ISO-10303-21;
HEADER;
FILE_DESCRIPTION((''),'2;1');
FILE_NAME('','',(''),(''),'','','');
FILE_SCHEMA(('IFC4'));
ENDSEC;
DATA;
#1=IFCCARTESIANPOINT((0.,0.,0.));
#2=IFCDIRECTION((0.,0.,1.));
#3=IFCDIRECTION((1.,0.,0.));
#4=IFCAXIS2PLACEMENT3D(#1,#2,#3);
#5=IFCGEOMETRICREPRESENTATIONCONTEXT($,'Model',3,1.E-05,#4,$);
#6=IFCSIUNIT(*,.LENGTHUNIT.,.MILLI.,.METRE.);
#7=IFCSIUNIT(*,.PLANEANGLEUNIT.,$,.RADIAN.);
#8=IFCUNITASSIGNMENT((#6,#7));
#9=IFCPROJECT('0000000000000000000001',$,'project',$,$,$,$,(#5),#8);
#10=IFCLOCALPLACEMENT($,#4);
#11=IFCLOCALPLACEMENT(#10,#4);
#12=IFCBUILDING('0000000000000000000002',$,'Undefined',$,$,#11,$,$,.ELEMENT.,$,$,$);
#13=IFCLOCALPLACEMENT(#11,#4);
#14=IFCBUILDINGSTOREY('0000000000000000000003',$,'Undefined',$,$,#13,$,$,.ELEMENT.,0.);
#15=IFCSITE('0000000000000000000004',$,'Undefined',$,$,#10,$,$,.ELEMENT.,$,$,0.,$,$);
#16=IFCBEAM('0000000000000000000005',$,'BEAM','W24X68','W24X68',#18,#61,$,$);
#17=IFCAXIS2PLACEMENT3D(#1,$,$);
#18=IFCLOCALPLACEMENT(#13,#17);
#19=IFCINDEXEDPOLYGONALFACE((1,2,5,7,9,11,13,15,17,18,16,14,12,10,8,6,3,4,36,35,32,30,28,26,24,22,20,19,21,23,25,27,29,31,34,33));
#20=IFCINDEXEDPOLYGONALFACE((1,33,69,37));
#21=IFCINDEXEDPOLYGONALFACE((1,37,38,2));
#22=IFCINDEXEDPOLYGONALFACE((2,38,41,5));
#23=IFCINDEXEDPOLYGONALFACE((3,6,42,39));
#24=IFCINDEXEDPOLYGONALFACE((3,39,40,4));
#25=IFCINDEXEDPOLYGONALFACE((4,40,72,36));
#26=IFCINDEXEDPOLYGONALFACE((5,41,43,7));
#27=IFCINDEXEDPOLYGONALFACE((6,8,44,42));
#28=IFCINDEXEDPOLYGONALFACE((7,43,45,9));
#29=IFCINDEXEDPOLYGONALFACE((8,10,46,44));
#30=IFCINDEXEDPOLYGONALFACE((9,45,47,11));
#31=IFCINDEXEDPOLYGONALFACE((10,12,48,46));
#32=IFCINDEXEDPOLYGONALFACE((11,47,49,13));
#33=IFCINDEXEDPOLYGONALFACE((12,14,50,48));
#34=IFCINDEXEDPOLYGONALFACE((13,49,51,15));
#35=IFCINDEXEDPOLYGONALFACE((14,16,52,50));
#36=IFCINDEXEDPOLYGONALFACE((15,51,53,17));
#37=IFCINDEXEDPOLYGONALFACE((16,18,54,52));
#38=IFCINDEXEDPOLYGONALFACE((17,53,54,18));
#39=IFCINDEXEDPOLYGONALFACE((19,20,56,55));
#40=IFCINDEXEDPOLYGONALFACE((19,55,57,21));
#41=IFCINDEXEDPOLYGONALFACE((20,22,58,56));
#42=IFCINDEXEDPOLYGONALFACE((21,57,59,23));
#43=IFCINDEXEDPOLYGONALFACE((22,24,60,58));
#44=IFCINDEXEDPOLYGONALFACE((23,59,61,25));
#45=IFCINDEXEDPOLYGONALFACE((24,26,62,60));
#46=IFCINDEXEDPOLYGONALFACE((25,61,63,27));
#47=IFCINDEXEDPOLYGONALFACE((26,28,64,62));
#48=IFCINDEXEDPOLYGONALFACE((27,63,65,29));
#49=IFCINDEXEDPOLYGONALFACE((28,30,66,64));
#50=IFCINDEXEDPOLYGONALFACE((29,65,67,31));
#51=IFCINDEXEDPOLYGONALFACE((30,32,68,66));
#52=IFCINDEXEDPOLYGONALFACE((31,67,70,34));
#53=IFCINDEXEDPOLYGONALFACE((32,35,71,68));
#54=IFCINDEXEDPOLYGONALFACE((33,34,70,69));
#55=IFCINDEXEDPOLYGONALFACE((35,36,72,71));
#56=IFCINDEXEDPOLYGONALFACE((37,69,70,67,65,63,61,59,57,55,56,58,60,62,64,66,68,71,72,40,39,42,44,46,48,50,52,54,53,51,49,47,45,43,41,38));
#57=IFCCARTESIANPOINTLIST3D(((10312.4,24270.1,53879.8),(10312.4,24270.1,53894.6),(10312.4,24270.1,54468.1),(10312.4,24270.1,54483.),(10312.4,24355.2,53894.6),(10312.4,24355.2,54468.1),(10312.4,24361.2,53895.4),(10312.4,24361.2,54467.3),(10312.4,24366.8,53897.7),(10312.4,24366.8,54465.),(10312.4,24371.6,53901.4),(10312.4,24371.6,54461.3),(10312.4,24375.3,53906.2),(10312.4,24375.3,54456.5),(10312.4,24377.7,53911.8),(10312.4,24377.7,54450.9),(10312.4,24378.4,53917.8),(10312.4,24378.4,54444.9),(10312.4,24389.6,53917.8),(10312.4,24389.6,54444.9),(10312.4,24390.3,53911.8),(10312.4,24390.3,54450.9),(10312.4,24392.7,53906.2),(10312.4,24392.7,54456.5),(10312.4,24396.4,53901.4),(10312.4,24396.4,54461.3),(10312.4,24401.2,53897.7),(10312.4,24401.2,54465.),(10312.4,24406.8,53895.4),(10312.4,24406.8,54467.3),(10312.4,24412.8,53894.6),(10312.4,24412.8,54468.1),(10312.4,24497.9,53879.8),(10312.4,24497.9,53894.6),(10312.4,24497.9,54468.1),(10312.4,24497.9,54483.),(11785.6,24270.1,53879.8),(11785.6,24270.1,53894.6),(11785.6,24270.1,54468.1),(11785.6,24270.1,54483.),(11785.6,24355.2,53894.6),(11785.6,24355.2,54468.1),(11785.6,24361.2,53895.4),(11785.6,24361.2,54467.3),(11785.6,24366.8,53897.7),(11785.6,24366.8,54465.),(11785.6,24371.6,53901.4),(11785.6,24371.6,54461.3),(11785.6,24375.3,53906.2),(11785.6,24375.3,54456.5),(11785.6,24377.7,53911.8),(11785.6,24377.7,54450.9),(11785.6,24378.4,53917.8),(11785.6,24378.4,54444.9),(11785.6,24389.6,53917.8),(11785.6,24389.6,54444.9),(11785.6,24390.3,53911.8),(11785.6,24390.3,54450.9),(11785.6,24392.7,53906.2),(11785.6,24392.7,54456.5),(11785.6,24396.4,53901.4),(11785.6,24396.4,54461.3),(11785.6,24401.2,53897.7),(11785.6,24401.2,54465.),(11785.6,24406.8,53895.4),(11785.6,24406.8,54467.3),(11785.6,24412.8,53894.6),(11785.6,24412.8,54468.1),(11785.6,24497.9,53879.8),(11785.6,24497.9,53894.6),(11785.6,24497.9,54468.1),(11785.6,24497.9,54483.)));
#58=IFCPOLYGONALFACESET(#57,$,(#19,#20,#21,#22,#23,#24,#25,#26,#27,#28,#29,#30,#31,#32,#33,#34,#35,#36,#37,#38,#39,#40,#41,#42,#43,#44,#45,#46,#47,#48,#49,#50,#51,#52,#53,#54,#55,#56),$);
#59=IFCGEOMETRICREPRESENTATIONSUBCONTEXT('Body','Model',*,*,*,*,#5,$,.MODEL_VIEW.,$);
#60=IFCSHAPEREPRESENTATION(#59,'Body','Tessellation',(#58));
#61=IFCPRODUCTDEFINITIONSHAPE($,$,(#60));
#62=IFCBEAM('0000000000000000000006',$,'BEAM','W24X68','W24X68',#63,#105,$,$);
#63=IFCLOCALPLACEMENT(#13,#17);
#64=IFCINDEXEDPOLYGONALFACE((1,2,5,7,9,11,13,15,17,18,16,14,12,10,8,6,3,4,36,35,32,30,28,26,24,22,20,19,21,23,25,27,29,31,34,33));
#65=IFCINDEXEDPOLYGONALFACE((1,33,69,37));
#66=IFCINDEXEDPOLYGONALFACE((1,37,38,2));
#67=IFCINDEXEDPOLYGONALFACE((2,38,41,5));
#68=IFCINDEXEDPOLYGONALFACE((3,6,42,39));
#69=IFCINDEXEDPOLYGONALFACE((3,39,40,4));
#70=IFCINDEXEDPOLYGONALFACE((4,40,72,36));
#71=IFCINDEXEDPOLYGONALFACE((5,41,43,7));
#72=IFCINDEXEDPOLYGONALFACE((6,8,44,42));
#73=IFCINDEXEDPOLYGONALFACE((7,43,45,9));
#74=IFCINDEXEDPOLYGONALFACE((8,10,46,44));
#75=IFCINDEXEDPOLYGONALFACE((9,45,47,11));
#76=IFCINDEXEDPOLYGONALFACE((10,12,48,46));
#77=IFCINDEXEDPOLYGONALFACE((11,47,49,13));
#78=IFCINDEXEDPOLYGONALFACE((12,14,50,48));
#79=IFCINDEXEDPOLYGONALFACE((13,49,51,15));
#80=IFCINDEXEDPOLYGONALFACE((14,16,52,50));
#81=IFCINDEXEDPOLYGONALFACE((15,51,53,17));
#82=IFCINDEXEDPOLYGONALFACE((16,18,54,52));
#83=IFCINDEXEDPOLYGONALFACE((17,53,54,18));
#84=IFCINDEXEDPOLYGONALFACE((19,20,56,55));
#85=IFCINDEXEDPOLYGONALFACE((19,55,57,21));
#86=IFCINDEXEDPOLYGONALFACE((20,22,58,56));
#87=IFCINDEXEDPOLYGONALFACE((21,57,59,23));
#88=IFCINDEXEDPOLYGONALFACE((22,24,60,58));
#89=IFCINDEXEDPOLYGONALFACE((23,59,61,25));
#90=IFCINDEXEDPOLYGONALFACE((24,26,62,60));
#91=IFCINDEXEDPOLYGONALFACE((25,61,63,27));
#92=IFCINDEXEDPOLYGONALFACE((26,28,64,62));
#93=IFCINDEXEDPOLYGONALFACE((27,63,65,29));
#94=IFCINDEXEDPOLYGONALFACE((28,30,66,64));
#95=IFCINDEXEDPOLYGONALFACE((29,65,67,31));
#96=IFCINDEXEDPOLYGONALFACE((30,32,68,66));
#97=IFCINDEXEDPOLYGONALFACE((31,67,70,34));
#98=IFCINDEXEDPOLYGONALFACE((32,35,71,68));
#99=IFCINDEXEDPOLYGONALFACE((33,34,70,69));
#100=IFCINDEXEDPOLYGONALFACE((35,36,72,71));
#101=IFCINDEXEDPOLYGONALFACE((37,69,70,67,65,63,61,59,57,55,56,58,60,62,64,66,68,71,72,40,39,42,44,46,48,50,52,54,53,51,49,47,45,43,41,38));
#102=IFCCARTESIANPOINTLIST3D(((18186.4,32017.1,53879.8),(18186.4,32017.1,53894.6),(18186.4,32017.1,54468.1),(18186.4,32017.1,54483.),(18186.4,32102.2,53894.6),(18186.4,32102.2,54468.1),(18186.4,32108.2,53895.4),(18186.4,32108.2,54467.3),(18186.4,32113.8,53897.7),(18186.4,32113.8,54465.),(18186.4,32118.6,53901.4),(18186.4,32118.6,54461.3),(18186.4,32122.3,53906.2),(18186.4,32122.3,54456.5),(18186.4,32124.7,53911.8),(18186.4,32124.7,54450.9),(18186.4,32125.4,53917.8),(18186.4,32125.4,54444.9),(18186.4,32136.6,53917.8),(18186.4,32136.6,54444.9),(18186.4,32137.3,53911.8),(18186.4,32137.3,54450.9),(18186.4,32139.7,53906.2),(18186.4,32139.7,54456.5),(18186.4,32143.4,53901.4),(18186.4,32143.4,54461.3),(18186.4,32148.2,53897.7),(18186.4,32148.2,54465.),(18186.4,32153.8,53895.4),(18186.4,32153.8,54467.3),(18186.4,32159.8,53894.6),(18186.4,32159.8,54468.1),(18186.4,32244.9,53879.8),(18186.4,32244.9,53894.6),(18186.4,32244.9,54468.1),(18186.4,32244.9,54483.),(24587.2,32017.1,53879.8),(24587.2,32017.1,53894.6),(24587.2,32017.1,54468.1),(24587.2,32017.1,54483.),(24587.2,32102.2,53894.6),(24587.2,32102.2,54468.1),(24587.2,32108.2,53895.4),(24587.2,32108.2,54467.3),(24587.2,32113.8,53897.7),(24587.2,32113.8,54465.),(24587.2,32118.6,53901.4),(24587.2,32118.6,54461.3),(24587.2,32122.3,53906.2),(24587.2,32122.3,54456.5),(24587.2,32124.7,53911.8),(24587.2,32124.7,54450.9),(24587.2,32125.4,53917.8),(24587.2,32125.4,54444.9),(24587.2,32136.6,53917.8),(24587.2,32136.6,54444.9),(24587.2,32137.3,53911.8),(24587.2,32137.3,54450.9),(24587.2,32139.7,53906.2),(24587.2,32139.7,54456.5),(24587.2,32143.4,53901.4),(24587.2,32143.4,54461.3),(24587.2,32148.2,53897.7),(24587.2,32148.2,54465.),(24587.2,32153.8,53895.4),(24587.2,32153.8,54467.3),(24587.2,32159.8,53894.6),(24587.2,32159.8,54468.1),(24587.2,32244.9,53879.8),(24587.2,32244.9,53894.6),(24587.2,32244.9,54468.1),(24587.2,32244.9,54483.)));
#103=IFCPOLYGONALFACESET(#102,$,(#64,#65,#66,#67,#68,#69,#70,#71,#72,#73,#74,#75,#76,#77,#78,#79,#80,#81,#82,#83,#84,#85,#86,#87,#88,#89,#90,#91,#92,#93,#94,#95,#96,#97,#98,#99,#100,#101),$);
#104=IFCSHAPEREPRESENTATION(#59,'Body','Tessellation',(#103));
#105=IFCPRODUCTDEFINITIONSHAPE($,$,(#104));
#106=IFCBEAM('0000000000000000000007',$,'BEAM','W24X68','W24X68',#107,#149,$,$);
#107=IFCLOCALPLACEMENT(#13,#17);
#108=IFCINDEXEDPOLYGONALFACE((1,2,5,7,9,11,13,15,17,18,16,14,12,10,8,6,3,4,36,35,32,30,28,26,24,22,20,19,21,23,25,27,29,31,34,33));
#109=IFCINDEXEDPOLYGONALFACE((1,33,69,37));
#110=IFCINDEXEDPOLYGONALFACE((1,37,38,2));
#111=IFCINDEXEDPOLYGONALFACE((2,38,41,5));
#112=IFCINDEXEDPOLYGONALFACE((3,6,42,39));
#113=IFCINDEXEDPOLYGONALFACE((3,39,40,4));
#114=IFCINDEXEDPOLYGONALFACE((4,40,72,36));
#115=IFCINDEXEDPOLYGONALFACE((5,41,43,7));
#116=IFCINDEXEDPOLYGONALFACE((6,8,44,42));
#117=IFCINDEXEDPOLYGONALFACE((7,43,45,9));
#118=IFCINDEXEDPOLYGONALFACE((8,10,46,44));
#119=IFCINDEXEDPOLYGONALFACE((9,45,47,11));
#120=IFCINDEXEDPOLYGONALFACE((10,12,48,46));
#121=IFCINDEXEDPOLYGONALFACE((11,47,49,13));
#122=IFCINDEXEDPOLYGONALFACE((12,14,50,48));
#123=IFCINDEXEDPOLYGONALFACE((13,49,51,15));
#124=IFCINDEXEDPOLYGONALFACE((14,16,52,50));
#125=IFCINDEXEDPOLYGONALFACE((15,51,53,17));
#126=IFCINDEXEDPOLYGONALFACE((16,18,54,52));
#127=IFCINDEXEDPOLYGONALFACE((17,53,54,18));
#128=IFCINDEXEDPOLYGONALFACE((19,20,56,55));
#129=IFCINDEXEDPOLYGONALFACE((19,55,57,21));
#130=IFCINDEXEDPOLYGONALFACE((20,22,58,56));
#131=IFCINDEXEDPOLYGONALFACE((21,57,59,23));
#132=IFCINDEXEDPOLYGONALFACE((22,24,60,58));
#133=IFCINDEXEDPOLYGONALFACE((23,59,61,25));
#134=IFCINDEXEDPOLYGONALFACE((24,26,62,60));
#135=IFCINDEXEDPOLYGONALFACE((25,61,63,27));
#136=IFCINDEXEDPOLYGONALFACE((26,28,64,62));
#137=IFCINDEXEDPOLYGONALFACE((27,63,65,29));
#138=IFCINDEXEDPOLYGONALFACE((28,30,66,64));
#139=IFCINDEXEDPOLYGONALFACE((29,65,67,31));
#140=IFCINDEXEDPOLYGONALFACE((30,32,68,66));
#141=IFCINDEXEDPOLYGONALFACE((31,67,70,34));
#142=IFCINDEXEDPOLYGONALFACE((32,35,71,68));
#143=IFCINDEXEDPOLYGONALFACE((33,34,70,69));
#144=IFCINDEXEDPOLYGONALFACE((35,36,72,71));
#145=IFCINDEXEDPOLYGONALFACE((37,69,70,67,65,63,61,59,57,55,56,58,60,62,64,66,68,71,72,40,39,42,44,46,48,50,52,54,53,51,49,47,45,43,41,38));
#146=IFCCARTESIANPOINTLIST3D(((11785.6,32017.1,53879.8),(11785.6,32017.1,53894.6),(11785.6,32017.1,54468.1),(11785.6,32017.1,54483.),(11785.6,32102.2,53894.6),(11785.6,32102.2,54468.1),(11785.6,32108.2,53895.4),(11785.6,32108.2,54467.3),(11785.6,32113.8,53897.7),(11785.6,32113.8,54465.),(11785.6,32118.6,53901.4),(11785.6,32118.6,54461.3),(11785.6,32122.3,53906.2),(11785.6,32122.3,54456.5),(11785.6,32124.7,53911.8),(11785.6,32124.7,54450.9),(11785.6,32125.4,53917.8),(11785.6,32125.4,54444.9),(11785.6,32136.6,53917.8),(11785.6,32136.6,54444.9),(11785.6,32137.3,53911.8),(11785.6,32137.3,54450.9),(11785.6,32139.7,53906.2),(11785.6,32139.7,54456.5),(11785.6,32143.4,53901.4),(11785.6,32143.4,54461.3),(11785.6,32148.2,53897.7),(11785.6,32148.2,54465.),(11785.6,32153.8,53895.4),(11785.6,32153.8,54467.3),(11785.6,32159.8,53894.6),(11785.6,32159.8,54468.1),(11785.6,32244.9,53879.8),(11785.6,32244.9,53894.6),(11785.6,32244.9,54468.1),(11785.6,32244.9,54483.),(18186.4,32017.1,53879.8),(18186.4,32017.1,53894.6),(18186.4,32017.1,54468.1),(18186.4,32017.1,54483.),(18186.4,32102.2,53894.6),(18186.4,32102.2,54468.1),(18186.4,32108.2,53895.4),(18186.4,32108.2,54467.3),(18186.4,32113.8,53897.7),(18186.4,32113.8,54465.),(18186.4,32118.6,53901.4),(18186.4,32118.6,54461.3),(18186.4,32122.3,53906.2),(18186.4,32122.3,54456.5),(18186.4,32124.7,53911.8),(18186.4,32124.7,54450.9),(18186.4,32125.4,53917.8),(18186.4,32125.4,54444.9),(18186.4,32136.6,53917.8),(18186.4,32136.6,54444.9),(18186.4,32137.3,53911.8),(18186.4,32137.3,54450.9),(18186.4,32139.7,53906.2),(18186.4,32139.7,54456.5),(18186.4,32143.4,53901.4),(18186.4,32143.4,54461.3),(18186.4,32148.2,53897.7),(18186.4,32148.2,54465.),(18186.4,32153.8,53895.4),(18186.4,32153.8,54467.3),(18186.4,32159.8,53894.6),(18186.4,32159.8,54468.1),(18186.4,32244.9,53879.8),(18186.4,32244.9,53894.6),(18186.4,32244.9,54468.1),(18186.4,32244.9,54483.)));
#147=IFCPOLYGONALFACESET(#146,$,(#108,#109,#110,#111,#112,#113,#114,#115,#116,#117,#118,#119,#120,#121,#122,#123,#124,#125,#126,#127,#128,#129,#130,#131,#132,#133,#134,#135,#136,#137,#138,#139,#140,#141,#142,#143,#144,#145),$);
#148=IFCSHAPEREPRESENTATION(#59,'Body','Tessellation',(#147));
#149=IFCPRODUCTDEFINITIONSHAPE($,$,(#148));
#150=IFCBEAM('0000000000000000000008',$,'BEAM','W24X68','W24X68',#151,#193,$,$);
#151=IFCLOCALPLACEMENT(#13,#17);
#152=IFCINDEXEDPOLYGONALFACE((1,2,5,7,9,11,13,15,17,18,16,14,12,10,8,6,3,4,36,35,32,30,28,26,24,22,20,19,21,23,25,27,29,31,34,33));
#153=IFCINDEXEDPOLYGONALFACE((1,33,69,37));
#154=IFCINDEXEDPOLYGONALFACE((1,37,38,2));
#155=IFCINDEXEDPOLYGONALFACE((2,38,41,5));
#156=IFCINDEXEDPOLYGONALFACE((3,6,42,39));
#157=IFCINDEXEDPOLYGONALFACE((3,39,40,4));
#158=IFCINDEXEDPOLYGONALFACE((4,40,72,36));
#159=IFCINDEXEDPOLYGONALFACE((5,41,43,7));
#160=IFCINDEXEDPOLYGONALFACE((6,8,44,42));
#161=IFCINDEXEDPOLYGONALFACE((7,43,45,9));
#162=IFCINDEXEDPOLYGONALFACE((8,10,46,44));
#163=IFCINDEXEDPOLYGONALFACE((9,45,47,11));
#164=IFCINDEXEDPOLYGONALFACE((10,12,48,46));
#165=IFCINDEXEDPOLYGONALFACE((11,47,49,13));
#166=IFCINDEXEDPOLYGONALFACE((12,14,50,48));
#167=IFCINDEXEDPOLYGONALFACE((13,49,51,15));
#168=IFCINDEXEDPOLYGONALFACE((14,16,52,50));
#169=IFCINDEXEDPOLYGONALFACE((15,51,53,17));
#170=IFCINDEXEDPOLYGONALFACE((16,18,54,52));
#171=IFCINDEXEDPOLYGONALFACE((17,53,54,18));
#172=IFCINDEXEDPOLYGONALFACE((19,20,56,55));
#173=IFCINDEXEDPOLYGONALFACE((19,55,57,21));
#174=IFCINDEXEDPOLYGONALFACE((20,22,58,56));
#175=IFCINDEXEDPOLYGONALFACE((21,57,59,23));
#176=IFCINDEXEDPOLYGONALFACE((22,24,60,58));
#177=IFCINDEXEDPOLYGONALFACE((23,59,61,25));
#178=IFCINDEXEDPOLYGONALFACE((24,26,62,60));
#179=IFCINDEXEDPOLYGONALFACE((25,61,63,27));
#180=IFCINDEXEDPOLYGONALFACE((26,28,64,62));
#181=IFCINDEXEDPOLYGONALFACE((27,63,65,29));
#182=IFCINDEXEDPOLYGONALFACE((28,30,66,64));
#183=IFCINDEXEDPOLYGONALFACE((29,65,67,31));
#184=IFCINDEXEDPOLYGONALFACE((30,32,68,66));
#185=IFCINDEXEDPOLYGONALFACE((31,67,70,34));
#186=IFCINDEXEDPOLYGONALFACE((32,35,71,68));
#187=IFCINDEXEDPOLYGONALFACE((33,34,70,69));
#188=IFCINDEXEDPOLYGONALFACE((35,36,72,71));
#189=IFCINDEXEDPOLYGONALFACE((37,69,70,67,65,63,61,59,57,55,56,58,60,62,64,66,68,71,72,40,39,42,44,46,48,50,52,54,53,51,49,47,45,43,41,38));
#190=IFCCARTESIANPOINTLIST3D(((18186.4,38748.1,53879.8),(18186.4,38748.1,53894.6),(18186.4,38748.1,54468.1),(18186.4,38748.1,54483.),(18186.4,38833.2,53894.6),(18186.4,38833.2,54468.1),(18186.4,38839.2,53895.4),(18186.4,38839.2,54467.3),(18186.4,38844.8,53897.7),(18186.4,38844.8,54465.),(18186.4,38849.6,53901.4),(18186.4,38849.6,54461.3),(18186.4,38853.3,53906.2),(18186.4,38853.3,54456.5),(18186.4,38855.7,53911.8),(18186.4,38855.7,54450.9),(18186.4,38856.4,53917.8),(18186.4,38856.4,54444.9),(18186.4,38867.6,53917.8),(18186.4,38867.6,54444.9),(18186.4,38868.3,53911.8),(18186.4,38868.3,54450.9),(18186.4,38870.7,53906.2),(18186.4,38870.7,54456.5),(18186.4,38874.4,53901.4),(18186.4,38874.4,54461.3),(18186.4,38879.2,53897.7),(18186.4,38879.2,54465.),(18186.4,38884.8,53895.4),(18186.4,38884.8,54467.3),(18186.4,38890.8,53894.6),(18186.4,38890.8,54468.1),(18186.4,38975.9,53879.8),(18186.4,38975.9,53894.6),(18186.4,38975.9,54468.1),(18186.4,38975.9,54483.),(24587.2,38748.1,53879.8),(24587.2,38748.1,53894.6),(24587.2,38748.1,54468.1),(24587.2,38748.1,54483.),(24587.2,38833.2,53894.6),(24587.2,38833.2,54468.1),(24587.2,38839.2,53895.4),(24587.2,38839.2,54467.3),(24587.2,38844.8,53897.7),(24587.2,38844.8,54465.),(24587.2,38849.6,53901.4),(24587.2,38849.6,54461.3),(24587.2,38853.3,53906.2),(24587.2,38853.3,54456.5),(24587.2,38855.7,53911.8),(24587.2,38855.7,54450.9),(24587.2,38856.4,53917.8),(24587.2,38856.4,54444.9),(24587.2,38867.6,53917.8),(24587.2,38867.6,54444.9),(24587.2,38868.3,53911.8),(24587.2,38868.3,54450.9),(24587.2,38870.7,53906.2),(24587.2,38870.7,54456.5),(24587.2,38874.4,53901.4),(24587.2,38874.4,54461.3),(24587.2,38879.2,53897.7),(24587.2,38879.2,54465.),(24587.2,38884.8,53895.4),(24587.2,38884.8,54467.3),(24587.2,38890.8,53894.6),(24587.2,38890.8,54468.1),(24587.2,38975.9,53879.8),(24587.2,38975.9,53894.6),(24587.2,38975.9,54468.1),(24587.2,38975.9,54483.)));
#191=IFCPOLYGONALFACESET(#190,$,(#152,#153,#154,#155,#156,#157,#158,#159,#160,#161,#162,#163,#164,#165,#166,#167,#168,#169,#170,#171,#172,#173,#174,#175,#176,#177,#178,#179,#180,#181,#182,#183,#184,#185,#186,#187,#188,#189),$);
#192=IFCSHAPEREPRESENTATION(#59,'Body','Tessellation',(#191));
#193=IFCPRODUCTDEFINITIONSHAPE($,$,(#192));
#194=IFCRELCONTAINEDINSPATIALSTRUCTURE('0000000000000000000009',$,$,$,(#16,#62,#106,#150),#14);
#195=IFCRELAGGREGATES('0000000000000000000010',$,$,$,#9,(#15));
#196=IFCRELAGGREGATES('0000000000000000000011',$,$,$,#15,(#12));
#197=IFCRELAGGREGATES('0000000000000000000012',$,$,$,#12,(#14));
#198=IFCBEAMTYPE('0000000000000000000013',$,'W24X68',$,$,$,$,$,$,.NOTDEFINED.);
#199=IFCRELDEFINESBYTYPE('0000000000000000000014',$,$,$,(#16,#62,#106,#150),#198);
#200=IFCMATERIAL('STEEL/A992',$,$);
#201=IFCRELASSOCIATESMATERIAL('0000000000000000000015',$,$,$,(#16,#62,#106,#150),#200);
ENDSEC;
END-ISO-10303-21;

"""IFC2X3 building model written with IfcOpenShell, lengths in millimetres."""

from ifc_helpers import new_model, si_unit, frame, origin_with_axes, origin_2d_with_axis, place, context, subcontext, project, spatial, i_section, extrude, material, type_object, element, save


model = new_model("IFC2X3")

# Units and contexts
model_context = context("Model", 3, precision=1e-05, world=origin_with_axes())
body_context = subcontext(model_context, "Body", "Model", "MODEL_VIEW")
ifc_project = project(units=[si_unit("LENGTHUNIT", "METRE", prefix="MILLI"), si_unit("PLANEANGLEUNIT", "RADIAN")], contexts=[model_context])

# Site, building, storey
site_placement = place(None, origin_with_axes())
site = spatial("IfcSite", under=ifc_project, at=site_placement, Name="Undefined", CompositionType="ELEMENT", RefElevation=0.0)
building_placement = place(site_placement, origin_with_axes())
building = spatial("IfcBuilding", under=site, at=building_placement, Name="Undefined", CompositionType="ELEMENT")
storey_placement = place(building_placement, origin_with_axes())
storey = spatial("IfcBuildingStorey", under=building, at=storey_placement, Name="Undefined", CompositionType="ELEMENT", Elevation=0.0)

# Shared definitions
ifc_material_1 = material(Name="STEEL/A992")

# Beams
beam_type_1 = type_object("IfcBeamType", Name="W24X68", PredefinedType="NOTDEFINED")
beam_1_placement = place(storey_placement, frame((10312.4, 24384.0, 54181.4), z_axis=(0.0, 0.0, 1.0), x_axis=(1.0, 0.0, 0.0)))
element("IfcBeam", 1, at=beam_1_placement, inside=storey, type_object=beam_type_1, material=ifc_material_1, Name="BEAM", Description="W24X68", ObjectType="W24X68", context=body_context, shape_type="SweptSolid", body=[
    extrude(i_section(OverallWidth=227.8, OverallDepth=603.2, WebThickness=11.1, FlangeThickness=14.9, FilletRadius=23.2, at=origin_2d_with_axis()), frame((1473.2, 0.0, 0.0), z_axis=(-1.0, 0.0, 0.0), x_axis=(0.0, -1.0, 0.0)), (0.0, 0.0, 1.0), 1473.2),
])
for number, where, z_axis, x_axis, name in (
    (2, (18186.4, 32131.0, 54181.4), (0.0, 0.0, 1.0), (1.0, 0.0, 0.0), "BEAM"),
    (3, (11785.6, 32131.0, 54181.4), (0.0, 0.0, 1.0), (1.0, 0.0, 0.0), "BEAM"),
    (4, (18186.4, 38862.0, 54181.4), (0.0, 0.0, 1.0), (1.0, 0.0, 0.0), "BEAM"),
):
    element("IfcBeam", number, at=place(storey_placement, frame(where, z_axis=z_axis, x_axis=x_axis)), inside=storey, type_object=beam_type_1, material=ifc_material_1, Name=name, Description="W24X68", ObjectType="W24X68", context=body_context, shape_type="SweptSolid", body=[
        extrude(i_section(OverallWidth=227.8, OverallDepth=603.2, WebThickness=11.1, FlangeThickness=14.9, FilletRadius=23.2, at=origin_2d_with_axis()), frame((6400.8, 0.0, 0.0), z_axis=(-1.0, 0.0, 0.0), x_axis=(0.0, -1.0, 0.0)), (0.0, 0.0, 1.0), 6400.8),
    ])

save(model, "model.ifc")
